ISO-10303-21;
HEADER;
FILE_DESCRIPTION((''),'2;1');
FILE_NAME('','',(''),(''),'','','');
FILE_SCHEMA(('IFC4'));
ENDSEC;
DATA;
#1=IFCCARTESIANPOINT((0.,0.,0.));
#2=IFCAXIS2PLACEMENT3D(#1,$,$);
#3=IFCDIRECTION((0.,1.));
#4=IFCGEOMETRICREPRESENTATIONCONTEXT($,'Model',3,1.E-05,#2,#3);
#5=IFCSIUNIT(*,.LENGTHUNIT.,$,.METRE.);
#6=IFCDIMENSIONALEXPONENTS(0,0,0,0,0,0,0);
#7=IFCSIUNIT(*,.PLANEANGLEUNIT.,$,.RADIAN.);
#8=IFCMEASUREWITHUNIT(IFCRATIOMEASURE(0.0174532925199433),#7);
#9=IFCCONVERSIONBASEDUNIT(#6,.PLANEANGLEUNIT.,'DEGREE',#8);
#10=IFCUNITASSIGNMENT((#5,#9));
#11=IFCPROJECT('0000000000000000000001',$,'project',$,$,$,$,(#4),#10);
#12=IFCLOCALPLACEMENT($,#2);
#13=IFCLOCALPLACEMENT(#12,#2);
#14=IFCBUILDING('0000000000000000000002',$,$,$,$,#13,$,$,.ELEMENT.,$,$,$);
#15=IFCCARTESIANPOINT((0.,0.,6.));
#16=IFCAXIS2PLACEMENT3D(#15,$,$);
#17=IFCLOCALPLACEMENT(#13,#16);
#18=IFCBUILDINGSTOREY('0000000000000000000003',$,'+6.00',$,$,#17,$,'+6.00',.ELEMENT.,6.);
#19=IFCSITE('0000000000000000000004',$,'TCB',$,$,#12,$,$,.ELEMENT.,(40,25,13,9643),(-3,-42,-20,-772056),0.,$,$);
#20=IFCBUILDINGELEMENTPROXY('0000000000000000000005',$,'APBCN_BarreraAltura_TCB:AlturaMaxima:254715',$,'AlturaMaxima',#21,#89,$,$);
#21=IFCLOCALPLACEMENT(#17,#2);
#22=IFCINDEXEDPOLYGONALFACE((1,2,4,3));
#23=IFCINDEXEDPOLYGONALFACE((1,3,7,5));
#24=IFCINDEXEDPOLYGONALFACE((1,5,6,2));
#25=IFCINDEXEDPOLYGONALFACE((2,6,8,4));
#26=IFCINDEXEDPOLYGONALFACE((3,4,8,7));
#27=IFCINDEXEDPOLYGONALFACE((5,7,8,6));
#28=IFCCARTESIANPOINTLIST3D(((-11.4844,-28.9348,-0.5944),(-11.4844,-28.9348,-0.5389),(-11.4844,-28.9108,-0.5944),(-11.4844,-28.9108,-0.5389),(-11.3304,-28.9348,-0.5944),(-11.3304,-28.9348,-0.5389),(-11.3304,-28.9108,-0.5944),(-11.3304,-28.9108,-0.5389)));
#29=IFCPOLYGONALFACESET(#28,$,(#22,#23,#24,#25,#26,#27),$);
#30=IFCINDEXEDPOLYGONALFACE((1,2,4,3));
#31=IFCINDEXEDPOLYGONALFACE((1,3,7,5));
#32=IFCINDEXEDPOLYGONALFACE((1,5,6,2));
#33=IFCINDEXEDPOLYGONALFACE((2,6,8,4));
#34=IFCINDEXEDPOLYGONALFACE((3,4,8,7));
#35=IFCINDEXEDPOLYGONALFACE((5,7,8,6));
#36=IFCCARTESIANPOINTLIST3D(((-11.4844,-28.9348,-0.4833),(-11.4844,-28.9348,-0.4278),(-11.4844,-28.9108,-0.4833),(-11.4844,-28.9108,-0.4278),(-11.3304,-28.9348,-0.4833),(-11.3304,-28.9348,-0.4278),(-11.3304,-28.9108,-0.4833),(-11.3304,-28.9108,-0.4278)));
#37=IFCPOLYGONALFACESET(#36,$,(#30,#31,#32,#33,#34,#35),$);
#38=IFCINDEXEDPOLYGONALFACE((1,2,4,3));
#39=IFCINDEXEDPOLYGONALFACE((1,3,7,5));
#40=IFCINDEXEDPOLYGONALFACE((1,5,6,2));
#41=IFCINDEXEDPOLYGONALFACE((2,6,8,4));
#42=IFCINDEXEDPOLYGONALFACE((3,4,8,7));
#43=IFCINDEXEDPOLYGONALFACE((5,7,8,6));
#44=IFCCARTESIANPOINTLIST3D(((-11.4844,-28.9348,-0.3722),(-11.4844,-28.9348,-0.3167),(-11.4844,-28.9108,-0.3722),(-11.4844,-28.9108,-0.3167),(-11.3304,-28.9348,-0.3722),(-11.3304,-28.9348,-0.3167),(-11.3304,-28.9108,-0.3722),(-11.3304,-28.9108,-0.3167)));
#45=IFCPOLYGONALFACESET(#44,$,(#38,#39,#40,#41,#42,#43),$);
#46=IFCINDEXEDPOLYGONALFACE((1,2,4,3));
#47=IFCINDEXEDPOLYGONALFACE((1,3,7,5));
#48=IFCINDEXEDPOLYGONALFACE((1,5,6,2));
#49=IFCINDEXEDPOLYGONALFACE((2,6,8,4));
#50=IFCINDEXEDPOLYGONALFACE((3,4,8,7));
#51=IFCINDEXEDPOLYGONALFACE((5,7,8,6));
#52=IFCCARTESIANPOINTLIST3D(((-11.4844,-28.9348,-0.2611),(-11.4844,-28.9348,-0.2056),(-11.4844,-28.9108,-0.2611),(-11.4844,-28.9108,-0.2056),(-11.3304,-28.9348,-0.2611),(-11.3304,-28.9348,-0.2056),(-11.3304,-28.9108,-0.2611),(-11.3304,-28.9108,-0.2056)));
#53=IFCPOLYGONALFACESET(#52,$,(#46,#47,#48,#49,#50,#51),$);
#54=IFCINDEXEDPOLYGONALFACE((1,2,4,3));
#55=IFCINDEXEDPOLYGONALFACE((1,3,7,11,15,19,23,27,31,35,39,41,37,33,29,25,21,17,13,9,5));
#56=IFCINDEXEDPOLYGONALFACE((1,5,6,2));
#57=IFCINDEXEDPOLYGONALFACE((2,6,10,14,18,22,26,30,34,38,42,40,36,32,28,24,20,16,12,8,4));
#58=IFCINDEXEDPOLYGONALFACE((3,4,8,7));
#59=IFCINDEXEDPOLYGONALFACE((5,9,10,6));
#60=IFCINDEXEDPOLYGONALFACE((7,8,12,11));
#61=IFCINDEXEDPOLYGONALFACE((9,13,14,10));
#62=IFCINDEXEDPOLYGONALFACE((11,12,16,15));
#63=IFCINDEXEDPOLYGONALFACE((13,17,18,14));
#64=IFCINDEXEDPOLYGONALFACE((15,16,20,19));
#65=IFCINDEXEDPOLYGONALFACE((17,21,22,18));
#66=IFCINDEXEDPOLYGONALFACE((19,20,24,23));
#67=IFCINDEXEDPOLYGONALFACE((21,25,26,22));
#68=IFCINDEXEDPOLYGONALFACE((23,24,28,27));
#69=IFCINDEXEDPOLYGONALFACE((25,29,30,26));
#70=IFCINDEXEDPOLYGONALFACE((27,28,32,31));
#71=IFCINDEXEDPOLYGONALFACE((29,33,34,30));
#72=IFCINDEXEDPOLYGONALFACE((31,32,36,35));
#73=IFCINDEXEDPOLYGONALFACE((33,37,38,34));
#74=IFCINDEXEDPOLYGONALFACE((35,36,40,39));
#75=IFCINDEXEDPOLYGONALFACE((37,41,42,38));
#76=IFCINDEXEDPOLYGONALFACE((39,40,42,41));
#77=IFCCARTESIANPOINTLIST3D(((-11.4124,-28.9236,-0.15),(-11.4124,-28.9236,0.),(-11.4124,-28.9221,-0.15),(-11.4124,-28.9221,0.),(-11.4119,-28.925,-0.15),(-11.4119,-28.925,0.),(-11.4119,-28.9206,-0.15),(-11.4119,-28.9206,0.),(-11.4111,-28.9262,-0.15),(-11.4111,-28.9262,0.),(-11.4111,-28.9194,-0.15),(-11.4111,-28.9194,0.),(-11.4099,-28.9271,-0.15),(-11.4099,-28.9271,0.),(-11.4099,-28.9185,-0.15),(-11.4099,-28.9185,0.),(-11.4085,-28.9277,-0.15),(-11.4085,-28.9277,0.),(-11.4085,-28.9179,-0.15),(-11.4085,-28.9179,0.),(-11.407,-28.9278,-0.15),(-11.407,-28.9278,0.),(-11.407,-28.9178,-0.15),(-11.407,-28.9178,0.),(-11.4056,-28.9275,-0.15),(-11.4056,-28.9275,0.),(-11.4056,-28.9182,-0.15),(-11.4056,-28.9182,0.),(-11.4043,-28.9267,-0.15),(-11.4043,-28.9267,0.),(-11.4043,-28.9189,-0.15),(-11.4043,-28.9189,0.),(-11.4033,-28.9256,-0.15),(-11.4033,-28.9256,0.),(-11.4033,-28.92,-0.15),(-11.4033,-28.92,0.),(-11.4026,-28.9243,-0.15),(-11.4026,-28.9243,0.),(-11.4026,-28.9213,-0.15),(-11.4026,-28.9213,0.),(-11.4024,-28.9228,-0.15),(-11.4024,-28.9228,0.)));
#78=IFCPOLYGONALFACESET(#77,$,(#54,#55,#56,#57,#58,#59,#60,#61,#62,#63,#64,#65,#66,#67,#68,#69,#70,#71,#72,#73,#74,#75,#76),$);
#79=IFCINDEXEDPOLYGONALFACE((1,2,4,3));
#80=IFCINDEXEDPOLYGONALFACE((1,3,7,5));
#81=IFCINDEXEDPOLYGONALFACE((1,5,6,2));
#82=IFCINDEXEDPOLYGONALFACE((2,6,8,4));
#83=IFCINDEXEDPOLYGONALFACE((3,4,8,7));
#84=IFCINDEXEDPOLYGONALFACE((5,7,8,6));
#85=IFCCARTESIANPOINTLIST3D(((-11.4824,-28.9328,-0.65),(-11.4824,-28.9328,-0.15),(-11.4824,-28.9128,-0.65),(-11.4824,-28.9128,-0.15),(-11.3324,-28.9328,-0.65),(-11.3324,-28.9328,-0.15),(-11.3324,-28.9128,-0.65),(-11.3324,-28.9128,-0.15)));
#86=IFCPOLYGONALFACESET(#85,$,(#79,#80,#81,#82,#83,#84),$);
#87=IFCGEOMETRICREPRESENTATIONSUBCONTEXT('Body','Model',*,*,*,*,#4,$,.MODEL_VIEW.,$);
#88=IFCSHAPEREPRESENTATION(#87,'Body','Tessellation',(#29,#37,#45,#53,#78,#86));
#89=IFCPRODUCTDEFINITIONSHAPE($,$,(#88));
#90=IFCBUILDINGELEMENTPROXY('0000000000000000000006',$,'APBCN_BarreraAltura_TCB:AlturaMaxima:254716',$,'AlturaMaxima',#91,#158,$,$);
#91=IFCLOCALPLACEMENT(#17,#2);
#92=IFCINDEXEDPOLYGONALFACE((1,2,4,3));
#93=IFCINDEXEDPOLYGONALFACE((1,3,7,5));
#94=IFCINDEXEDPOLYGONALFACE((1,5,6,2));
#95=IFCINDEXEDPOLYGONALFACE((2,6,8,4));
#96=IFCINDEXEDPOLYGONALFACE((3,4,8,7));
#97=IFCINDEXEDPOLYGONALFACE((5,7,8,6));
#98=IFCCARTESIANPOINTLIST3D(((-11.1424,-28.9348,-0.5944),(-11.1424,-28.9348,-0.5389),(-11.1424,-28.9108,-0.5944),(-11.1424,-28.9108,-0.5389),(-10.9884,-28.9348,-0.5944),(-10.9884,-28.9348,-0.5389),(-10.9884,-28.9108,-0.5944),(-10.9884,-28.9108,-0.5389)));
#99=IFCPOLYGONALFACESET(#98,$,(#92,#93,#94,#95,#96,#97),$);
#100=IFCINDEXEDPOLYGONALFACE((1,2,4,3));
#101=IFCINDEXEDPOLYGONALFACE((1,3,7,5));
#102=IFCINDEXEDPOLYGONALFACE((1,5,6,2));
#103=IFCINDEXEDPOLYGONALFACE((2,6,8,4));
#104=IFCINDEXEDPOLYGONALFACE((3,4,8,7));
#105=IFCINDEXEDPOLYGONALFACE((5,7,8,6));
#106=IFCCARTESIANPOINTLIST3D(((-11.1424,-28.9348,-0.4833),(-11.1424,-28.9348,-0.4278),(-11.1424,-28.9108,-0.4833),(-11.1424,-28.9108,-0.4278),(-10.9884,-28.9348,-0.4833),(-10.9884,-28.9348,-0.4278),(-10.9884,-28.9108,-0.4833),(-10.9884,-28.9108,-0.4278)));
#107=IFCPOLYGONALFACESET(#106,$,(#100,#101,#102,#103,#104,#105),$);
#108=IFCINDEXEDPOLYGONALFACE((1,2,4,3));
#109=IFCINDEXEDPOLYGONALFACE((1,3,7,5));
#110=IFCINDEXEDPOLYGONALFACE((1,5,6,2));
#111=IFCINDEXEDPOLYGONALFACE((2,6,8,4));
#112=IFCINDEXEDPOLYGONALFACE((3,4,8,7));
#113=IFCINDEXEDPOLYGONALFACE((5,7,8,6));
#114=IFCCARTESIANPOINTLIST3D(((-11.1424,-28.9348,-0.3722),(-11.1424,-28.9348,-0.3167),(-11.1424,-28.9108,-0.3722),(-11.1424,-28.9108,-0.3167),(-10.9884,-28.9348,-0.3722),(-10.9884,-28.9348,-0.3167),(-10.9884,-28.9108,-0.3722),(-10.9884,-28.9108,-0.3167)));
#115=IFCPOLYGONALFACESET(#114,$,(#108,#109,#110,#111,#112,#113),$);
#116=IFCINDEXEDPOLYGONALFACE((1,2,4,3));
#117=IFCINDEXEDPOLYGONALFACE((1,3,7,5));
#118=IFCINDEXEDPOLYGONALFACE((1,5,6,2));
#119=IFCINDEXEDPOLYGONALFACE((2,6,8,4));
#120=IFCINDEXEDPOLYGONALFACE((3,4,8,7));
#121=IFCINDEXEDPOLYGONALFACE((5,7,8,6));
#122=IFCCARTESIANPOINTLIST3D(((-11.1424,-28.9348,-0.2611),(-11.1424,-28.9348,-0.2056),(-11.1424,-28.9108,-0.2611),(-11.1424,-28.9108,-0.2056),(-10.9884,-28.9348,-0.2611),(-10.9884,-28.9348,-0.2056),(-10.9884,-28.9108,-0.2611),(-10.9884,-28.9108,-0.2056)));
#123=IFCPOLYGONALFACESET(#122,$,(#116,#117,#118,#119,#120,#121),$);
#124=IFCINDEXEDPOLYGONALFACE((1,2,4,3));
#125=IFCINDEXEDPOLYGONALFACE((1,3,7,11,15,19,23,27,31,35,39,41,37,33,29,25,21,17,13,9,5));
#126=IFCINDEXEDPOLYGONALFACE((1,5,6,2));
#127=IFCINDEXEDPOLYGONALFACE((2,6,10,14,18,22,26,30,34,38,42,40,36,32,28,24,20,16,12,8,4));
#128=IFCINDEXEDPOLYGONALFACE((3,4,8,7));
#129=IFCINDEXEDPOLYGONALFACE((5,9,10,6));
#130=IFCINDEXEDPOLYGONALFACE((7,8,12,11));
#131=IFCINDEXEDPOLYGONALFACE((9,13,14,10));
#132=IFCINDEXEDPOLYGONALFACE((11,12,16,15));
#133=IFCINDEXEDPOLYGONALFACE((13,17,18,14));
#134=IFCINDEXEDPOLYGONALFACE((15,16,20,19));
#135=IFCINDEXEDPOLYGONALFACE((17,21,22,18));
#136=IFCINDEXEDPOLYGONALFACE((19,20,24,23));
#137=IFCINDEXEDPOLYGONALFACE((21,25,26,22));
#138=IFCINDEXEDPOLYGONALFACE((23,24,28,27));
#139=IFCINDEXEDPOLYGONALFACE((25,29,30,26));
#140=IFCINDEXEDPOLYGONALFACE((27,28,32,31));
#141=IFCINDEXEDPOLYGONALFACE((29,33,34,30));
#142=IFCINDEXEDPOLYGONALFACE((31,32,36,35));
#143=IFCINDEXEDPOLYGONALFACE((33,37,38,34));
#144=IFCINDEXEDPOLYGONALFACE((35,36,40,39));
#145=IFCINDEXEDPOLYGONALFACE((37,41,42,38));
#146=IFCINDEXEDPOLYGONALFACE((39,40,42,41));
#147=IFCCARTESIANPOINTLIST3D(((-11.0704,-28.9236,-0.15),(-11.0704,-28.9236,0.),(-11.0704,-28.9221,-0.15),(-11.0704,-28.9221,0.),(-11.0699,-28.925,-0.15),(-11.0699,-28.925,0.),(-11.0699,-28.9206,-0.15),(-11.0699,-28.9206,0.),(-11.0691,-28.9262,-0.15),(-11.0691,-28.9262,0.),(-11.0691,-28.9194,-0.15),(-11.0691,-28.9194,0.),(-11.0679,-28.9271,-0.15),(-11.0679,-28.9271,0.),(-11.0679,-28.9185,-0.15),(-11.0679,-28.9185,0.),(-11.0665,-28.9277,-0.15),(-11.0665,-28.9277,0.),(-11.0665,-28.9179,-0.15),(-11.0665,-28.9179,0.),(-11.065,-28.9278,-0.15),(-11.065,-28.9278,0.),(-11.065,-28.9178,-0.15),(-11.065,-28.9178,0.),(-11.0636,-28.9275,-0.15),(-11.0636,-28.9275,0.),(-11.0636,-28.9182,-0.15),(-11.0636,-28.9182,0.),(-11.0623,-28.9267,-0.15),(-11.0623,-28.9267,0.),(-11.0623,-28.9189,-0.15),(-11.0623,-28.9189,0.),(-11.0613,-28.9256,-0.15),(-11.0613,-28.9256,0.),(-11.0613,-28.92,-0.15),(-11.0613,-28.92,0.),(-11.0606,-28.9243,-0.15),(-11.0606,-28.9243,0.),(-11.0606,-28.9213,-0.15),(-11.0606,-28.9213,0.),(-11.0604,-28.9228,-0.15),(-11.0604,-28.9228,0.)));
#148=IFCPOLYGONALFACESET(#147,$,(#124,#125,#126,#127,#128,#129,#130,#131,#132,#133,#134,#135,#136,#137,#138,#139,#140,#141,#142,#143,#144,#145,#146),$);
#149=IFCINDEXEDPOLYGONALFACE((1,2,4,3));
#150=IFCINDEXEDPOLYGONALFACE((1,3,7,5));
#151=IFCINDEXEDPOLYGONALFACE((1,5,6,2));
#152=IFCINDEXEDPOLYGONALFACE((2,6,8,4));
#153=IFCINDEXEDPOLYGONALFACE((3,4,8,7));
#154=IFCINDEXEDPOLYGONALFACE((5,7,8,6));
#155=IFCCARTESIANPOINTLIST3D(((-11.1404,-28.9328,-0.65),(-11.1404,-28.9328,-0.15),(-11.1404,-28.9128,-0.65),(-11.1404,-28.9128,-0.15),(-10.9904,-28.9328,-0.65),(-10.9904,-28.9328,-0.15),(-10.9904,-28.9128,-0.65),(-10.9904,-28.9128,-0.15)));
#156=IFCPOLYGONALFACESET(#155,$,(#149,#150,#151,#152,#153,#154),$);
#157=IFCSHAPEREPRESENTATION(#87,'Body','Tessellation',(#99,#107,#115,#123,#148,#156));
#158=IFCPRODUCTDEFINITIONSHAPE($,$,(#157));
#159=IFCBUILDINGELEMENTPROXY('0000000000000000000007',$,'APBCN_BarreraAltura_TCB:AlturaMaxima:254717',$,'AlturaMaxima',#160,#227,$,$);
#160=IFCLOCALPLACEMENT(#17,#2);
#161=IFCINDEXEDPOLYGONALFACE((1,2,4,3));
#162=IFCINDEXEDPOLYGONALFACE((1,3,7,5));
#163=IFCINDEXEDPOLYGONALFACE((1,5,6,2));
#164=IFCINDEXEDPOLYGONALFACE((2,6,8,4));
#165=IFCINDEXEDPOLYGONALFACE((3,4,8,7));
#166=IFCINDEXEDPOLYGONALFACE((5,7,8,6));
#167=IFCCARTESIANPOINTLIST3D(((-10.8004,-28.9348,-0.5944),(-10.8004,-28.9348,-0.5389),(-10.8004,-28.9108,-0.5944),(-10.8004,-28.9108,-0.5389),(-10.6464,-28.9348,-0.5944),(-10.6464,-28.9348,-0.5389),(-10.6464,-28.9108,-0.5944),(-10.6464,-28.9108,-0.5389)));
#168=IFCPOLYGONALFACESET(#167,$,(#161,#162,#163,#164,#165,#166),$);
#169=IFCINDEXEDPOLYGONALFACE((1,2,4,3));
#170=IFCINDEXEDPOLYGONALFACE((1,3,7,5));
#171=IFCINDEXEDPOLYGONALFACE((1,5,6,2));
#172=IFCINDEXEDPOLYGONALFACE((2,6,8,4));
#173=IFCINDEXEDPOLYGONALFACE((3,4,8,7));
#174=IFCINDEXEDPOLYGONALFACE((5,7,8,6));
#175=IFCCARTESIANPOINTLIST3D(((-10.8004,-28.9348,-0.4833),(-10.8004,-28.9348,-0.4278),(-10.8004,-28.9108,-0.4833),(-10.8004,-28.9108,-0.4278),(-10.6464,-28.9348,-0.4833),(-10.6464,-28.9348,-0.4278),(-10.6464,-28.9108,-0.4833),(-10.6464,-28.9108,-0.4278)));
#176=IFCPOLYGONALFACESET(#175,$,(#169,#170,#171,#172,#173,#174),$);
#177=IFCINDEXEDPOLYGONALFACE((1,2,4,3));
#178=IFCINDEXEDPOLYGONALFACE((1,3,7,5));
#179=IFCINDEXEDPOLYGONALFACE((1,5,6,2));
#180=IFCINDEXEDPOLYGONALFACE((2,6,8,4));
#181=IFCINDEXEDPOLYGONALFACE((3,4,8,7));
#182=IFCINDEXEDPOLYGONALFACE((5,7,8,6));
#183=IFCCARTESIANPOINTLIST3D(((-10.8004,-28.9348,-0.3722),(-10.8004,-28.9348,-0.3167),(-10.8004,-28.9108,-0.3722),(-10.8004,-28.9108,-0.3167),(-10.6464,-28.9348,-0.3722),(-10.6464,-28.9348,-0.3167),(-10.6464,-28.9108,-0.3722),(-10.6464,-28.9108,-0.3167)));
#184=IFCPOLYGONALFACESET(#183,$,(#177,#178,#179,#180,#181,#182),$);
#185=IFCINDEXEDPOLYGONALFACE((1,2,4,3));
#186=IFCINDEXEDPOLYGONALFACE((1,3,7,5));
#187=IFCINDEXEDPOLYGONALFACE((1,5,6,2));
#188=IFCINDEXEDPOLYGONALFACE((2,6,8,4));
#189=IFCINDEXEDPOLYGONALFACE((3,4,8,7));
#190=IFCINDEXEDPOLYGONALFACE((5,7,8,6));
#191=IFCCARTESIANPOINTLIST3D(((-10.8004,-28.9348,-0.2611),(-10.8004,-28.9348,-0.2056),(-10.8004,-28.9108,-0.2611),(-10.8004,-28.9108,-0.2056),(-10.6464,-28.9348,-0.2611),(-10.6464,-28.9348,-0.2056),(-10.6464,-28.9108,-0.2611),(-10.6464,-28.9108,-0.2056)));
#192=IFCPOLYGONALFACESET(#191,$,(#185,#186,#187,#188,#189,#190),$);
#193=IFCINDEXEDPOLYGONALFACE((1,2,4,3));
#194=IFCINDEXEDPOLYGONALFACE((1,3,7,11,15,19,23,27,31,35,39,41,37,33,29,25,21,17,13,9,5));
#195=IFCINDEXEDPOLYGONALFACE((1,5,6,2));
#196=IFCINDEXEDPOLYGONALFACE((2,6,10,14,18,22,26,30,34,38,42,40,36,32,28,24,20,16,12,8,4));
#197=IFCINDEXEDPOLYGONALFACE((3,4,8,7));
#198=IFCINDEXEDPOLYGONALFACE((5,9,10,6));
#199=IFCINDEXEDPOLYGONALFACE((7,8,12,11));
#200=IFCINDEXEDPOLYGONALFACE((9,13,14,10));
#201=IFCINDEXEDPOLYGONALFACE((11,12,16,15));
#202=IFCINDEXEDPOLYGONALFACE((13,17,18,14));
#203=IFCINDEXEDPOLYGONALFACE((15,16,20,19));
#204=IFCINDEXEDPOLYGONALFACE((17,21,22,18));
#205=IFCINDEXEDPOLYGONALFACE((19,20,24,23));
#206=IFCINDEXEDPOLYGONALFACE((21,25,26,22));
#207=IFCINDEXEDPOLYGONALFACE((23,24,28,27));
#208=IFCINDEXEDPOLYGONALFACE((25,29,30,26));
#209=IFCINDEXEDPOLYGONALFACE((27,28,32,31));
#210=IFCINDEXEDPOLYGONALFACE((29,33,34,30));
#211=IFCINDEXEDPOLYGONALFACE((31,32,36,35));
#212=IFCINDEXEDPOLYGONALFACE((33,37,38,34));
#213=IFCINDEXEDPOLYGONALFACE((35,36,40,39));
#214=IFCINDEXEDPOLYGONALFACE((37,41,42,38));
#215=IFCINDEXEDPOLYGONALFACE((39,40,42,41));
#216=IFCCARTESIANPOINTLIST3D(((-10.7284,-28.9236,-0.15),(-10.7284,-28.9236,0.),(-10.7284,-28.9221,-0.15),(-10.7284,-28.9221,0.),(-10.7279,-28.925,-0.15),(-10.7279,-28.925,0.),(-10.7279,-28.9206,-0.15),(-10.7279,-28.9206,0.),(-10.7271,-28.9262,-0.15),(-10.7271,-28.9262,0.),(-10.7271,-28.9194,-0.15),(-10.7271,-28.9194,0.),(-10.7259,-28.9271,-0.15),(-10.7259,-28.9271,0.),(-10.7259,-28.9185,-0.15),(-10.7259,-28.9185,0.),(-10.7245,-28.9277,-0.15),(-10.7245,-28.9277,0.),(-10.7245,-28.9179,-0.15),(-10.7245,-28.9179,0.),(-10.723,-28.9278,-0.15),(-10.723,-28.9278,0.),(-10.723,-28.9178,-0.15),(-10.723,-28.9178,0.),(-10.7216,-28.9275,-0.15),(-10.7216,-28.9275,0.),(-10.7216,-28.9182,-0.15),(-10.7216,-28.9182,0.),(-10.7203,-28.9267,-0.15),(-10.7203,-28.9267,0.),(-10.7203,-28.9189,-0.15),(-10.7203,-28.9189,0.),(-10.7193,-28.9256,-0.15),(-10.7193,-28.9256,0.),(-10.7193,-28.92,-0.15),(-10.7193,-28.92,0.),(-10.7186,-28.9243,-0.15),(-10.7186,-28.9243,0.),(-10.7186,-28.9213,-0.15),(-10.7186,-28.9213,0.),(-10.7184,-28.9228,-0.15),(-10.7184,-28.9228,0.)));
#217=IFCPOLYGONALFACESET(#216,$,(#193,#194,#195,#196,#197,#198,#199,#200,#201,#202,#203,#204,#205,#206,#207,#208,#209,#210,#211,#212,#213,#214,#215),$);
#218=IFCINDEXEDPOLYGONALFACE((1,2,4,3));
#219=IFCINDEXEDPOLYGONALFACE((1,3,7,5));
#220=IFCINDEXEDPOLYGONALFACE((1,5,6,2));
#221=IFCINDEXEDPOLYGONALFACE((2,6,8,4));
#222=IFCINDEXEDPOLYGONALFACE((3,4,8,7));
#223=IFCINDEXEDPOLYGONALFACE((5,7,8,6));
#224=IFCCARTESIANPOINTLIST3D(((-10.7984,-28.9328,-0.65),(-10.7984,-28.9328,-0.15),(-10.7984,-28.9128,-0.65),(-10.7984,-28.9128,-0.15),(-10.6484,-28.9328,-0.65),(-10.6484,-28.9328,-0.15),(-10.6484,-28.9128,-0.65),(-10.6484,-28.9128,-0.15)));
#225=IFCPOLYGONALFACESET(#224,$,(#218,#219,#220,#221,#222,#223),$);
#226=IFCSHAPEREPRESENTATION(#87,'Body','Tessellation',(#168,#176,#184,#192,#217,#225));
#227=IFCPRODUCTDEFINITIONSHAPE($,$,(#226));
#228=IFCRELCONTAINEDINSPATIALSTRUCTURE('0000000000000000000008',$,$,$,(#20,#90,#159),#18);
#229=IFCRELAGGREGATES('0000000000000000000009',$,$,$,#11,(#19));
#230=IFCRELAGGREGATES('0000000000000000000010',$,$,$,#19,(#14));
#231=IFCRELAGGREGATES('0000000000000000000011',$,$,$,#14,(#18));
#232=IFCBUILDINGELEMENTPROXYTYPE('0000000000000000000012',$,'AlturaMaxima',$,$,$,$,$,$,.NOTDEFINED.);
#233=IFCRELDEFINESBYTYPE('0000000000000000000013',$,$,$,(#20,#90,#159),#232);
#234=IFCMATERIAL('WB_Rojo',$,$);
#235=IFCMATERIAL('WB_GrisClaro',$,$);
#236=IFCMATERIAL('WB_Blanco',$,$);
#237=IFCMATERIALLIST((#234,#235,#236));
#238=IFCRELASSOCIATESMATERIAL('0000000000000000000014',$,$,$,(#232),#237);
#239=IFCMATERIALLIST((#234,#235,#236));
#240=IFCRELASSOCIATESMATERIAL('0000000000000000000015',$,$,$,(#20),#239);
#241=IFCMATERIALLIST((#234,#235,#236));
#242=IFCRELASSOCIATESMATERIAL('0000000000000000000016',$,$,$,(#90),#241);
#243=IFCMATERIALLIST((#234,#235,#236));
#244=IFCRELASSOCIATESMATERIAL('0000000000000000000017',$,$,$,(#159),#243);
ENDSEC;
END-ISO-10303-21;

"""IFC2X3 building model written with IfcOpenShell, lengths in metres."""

from ifc_helpers import new_model, entity, si_unit, converted_unit, direction, frame, frame_2d, origin, origin_2d_with_axis, place, context, subcontext, project, spatial, rectangle, circle, extrude, source, transform, mapped, material, material_list, type_object, type_shapes, element, save


model = new_model("IFC2X3")

# Units and contexts
model_context = context("Model", 3, precision=1e-05, world=origin(), true_north=direction((0.0, 1.0)))
body_context = subcontext(model_context, "Body", "Model", "MODEL_VIEW")
ifc_project = project(units=[si_unit("LENGTHUNIT", "METRE"), converted_unit("PLANEANGLEUNIT", "DEGREE", entity("IfcRatioMeasure", 0.0174532925199433), si_unit("PLANEANGLEUNIT", "RADIAN"), dimensions=[0, 0, 0, 0, 0, 0, 0])], contexts=[model_context])

# Site, building, storey
site_placement = place(None, origin())
site = spatial("IfcSite", under=ifc_project, at=site_placement, Name="TCB", CompositionType="ELEMENT", RefLatitude=(40, 25, 13, 9643), RefLongitude=(-3, -42, -20, -772056), RefElevation=0.0)
building_placement = place(site_placement, origin())
building = spatial("IfcBuilding", under=site, at=building_placement, CompositionType="ELEMENT")
storey_placement = place(building_placement, frame((0.0, 0.0, 6.0)))
storey = spatial("IfcBuildingStorey", under=building, at=storey_placement, Name="+6.00", LongName="+6.00", CompositionType="ELEMENT", Elevation=6.0)

# Building element proxies
ifc_material_1 = material(Name="WB_Rojo")
ifc_material_2 = material(Name="WB_GrisClaro")
ifc_material_3 = material(Name="WB_Blanco")
ifc_material_list_1 = material_list([ifc_material_1, ifc_material_2, ifc_material_3])
building_element_proxy_type = type_object("IfcBuildingElementProxyType", Name="AlturaMaxima", PredefinedType="NOTDEFINED", material=ifc_material_list_1)
shared_shape = source(origin(), body_context, "Body", "SweptSolid", [
    extrude(rectangle(XDim=0.154, YDim=0.024, at=frame_2d((0.0, 0.0), x_axis=(1.0, 0.0))), frame((0.0, 0.0, -0.5944), z_axis=(0.0, 0.0, 1.0), x_axis=(-1.0, 0.0, 0.0)), (0.0, 0.0, 1.0), 0.0556),
    extrude(rectangle(XDim=0.154, YDim=0.024, at=frame_2d((0.0, 0.0), x_axis=(1.0, 0.0))), frame((0.0, 0.0, -0.4833), z_axis=(0.0, 0.0, 1.0), x_axis=(-1.0, 0.0, 0.0)), (0.0, 0.0, 1.0), 0.0556),
    extrude(rectangle(XDim=0.154, YDim=0.024, at=frame_2d((0.0, 0.0), x_axis=(1.0, 0.0))), frame((0.0, 0.0, -0.3722), z_axis=(0.0, 0.0, 1.0), x_axis=(-1.0, 0.0, 0.0)), (0.0, 0.0, 1.0), 0.0556),
    extrude(rectangle(XDim=0.154, YDim=0.024, at=frame_2d((0.0, 0.0), x_axis=(1.0, 0.0))), frame((0.0, 0.0, -0.2611), z_axis=(0.0, 0.0, 1.0), x_axis=(-1.0, 0.0, 0.0)), (0.0, 0.0, 1.0), 0.0556),
    extrude(circle(Radius=0.005, at=frame_2d((0.0, 0.0), x_axis=(1.0, 0.0))), frame((0.0, 0.0, -0.15)), (0.0, 0.0, 1.0), 0.15),
    extrude(rectangle(XDim=0.02, YDim=0.15, at=origin_2d_with_axis()), frame((0.0, 0.0, -0.65), z_axis=(0.0, 0.0, 1.0), x_axis=(0.0, 1.0, 0.0)), (0.0, 0.0, 1.0), 0.5),
])
type_shapes(building_element_proxy_type, [shared_shape])
ifc_material_list_2 = material_list([ifc_material_1, ifc_material_2, ifc_material_3])
proxy_1_placement = place(storey_placement, frame((-11.4074, -28.9228, 0.0)))
element("IfcBuildingElementProxy", 1, at=proxy_1_placement, inside=storey, type_object=building_element_proxy_type, material=ifc_material_list_2, Name="APBCN_BarreraAltura_TCB:AlturaMaxima:254715", ObjectType="AlturaMaxima", context=body_context, shape_type="MappedRepresentation", body=[
    mapped(shared_shape, transform((0.0, 0.0, 0.0), scale=1.0)),
])
ifc_material_list_3 = material_list([ifc_material_1, ifc_material_2, ifc_material_3])
proxy_2_placement = place(storey_placement, frame((-11.0654, -28.9228, 0.0)))
element("IfcBuildingElementProxy", 2, at=proxy_2_placement, inside=storey, type_object=building_element_proxy_type, material=ifc_material_list_3, Name="APBCN_BarreraAltura_TCB:AlturaMaxima:254716", ObjectType="AlturaMaxima", context=body_context, shape_type="MappedRepresentation", body=[
    mapped(shared_shape, transform((0.0, 0.0, 0.0), scale=1.0)),
])
ifc_material_list_4 = material_list([ifc_material_1, ifc_material_2, ifc_material_3])
proxy_3_placement = place(storey_placement, frame((-10.7234, -28.9228, 0.0)))
element("IfcBuildingElementProxy", 3, at=proxy_3_placement, inside=storey, type_object=building_element_proxy_type, material=ifc_material_list_4, Name="APBCN_BarreraAltura_TCB:AlturaMaxima:254717", ObjectType="AlturaMaxima", context=body_context, shape_type="MappedRepresentation", body=[
    mapped(shared_shape, transform((0.0, 0.0, 0.0), scale=1.0)),
])

save(model, "model.ifc")
